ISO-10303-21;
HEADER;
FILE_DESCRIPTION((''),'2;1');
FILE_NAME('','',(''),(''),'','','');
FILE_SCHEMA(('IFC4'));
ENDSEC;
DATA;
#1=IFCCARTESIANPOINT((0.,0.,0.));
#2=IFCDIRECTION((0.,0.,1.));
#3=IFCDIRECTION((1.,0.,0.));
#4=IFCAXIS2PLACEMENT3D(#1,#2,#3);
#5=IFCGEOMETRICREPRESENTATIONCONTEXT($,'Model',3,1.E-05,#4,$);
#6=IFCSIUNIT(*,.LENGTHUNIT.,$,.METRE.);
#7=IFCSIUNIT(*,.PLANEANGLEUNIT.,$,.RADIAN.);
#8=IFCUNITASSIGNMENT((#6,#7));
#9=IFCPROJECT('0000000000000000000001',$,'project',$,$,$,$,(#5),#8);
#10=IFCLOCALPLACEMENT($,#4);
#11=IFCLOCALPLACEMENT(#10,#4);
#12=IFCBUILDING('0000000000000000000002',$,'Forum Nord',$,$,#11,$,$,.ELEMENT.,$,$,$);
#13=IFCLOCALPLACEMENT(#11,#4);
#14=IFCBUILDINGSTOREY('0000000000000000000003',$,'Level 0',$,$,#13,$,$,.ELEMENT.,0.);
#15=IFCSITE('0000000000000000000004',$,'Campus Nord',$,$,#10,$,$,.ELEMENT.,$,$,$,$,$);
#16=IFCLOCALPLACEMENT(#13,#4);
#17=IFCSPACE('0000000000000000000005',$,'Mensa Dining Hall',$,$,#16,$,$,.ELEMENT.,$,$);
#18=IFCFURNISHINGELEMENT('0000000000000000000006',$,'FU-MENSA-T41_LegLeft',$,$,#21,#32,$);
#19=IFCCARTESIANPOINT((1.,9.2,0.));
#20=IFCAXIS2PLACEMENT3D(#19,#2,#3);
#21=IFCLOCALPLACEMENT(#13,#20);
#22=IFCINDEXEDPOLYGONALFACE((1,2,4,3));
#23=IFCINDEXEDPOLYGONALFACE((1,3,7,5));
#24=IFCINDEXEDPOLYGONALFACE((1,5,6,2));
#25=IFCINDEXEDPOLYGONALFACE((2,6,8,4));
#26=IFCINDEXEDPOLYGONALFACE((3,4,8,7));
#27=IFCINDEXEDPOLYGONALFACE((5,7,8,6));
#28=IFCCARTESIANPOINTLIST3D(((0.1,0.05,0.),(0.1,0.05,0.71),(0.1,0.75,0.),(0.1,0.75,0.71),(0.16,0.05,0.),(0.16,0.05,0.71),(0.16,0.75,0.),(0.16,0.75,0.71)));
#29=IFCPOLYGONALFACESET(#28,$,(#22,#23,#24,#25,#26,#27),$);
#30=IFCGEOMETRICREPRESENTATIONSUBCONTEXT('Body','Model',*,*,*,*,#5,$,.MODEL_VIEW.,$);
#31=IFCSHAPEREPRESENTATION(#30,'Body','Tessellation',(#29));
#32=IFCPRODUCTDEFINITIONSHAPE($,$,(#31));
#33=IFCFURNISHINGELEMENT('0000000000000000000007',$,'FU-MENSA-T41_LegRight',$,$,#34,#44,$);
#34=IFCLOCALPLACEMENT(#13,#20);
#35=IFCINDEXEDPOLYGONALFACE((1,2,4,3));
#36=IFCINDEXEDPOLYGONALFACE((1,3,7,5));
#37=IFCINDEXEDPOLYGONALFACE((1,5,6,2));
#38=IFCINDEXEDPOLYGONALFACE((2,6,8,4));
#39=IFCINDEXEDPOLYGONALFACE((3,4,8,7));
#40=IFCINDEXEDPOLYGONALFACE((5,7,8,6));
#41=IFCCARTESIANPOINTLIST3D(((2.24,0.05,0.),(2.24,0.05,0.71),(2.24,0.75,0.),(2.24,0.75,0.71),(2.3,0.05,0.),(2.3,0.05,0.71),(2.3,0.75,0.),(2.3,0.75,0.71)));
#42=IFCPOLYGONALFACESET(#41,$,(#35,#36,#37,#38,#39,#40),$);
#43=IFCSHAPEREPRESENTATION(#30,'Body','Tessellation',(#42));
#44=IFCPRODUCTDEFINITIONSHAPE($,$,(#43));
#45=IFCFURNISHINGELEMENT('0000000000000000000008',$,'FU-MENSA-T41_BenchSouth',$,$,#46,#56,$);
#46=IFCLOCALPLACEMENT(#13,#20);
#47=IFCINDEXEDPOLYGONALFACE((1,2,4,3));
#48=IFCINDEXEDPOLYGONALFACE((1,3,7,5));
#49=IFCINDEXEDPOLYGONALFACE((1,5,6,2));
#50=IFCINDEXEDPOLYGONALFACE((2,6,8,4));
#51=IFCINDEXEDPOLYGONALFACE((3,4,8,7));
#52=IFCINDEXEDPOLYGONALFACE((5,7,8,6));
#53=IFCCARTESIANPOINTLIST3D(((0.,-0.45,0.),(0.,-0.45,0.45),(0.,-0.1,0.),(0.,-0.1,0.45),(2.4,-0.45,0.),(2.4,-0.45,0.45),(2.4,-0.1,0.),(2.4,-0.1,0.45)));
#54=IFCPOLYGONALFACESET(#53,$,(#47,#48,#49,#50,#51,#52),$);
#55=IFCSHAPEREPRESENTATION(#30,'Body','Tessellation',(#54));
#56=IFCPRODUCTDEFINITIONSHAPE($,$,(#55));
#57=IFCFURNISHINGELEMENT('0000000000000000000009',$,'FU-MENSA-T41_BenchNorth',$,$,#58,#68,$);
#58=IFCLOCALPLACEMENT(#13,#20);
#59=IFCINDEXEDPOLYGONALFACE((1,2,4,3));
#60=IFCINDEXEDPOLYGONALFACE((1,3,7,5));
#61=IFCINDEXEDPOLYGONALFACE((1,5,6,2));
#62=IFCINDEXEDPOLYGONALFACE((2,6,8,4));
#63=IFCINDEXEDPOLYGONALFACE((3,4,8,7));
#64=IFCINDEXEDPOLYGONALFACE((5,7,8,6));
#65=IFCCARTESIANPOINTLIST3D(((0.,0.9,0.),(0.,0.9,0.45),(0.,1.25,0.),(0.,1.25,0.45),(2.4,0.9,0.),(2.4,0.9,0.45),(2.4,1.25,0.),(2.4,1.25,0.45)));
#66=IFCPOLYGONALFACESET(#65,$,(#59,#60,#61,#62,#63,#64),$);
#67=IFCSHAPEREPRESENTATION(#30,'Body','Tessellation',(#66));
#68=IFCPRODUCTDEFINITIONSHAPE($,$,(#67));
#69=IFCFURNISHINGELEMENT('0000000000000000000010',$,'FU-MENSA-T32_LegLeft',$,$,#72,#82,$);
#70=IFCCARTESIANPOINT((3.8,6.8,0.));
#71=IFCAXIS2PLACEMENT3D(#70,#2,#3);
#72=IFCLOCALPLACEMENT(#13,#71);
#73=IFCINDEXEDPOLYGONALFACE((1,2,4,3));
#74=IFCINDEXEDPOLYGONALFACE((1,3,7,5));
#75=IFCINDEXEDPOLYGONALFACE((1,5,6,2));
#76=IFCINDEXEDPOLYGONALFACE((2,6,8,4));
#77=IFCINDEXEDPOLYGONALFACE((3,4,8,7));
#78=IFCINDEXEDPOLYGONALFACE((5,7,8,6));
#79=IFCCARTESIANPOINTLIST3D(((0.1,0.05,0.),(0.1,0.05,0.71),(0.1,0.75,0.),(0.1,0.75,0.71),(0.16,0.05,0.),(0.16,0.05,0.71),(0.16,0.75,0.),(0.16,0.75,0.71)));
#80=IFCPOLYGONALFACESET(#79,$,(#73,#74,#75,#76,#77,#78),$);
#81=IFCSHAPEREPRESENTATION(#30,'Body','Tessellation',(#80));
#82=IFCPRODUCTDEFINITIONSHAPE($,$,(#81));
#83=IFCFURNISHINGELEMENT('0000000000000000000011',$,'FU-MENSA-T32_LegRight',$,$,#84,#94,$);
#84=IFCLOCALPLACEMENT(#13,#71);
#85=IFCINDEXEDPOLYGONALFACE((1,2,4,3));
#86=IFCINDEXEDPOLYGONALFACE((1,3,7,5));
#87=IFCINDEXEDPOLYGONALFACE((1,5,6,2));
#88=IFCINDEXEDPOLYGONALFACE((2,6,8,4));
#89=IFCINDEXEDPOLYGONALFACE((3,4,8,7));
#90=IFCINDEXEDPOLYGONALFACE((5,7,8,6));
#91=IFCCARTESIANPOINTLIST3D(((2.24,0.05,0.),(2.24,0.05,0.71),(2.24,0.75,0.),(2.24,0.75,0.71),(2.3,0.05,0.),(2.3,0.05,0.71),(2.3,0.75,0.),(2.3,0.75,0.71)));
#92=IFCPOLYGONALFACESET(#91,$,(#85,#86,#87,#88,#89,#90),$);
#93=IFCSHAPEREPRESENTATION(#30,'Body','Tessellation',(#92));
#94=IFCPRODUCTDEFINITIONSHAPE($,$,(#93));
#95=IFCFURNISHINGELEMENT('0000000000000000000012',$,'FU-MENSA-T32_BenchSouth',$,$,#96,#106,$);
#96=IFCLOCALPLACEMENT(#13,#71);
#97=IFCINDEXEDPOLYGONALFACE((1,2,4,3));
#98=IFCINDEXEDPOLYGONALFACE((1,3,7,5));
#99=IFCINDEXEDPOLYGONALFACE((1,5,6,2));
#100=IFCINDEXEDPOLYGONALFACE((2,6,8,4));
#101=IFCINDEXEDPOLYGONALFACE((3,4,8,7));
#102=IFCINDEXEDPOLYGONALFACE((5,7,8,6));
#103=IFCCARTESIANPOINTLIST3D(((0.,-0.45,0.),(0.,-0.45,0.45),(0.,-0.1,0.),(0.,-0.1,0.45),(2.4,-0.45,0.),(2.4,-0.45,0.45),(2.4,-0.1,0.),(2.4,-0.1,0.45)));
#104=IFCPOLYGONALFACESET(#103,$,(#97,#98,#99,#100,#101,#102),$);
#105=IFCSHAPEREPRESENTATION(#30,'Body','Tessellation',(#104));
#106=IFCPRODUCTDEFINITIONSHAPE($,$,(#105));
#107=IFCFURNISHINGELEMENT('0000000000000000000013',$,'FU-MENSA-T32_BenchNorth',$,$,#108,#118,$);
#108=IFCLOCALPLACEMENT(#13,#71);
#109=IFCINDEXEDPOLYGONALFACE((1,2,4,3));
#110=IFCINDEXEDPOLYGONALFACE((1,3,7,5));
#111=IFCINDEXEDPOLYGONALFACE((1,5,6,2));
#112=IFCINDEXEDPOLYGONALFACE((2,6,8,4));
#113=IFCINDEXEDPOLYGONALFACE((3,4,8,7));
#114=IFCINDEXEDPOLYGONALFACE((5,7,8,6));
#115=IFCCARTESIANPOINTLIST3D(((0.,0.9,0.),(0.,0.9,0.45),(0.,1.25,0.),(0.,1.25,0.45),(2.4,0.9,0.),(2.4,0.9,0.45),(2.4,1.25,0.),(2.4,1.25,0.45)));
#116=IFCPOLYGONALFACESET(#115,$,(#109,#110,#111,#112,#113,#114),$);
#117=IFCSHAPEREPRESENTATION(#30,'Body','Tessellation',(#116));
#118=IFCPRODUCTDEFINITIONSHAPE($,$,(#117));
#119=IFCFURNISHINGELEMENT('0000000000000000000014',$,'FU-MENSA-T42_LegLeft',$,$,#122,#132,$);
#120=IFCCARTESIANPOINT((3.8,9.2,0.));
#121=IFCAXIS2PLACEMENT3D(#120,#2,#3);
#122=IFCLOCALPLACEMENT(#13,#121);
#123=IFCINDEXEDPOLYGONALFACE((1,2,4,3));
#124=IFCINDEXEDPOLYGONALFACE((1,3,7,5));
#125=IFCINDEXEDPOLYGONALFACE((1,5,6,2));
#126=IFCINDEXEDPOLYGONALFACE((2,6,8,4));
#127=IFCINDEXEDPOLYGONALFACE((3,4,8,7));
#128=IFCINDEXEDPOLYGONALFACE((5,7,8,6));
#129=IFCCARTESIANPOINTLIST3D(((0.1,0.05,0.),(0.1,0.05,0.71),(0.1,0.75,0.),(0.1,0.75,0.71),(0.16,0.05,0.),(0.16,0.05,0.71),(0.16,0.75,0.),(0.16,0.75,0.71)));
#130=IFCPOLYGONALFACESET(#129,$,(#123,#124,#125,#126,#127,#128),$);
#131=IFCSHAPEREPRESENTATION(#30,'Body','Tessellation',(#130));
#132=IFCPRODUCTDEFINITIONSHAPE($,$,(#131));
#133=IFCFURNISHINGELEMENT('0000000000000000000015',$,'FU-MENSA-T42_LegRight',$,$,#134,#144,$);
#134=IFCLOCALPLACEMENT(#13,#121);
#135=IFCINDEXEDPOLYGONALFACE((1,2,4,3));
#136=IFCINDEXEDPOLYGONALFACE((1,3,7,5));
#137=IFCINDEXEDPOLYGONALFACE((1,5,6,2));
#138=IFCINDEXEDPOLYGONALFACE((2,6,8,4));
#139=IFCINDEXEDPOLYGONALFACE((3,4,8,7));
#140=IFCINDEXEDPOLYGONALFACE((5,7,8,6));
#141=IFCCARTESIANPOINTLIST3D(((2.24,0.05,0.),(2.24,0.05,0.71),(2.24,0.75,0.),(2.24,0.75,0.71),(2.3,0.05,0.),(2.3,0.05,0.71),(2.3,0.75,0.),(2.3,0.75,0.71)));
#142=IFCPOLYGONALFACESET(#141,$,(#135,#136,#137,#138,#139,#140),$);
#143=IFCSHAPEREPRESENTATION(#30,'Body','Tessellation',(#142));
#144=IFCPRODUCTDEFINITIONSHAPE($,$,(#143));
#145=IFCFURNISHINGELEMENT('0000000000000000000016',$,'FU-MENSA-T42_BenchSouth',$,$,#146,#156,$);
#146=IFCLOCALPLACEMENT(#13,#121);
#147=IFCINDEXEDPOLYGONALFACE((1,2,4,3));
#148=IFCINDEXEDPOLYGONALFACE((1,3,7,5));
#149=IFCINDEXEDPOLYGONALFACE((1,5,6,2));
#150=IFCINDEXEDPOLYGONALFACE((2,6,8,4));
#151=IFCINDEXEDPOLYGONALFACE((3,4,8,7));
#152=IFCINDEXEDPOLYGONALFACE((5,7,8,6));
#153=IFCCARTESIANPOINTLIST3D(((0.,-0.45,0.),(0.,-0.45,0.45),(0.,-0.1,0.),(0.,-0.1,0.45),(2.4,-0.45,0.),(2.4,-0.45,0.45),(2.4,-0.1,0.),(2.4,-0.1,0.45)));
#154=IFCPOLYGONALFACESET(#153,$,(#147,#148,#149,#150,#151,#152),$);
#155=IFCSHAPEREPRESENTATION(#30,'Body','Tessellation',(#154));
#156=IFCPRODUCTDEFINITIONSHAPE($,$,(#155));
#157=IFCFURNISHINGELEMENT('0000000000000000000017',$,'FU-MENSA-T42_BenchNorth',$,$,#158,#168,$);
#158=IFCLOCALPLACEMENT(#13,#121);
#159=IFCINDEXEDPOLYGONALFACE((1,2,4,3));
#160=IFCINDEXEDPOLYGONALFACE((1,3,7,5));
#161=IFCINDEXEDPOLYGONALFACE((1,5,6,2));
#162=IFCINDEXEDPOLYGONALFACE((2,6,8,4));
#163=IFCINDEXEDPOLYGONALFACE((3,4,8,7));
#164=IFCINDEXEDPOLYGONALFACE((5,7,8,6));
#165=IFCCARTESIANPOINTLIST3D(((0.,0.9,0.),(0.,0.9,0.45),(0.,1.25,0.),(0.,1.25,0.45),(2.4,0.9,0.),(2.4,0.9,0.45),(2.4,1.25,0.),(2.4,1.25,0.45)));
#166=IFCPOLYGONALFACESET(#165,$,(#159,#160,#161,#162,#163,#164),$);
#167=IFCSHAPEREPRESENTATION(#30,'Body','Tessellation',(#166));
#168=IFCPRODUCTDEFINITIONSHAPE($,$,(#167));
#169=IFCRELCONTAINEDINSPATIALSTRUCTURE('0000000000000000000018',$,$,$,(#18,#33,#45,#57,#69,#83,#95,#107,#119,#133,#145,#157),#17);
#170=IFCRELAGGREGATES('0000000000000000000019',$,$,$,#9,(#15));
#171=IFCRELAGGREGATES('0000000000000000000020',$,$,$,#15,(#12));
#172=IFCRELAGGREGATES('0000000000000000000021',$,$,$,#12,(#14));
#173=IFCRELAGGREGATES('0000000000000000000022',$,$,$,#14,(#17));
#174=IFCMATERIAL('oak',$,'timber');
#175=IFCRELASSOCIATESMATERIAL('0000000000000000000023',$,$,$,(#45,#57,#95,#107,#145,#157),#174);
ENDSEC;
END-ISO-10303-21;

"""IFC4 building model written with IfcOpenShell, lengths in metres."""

from ifc_helpers import new_model, si_unit, frame, frame_2d, origin_with_axes, place, context, subcontext, project, spatial, rectangle, extrude, material, element, save


model = new_model("IFC4")

# Units and contexts
model_context = context("Model", 3, precision=1e-05, world=origin_with_axes())
body_context = subcontext(model_context, "Body", "Model", "MODEL_VIEW")
ifc_project = project(units=[si_unit("LENGTHUNIT", "METRE"), si_unit("PLANEANGLEUNIT", "RADIAN")], contexts=[model_context])

# Site, building, storey
site_placement = place(None, origin_with_axes())
site = spatial("IfcSite", under=ifc_project, at=site_placement, Name="Campus Nord", CompositionType="ELEMENT")
building_placement = place(site_placement, origin_with_axes())
building = spatial("IfcBuilding", under=site, at=building_placement, Name="Forum Nord", CompositionType="ELEMENT")
storey_placement = place(building_placement, origin_with_axes())
storey = spatial("IfcBuildingStorey", under=building, at=storey_placement, Name="Level 0", CompositionType="ELEMENT", Elevation=0.0)

# Shared definitions
space_placement = place(storey_placement, origin_with_axes())
space = spatial("IfcSpace", under=storey, at=space_placement, Name="Mensa Dining Hall", CompositionType="ELEMENT")

# Furnishing elements
ifc_material_1 = material(Name="oak", Category="timber")
furnishing_1_placement = place(storey_placement, frame((1.0, 9.2, 0.0), z_axis=(0.0, 0.0, 1.0), x_axis=(1.0, 0.0, 0.0)))
element("IfcFurnishingElement", 1, at=furnishing_1_placement, inside=space, Name="FU-MENSA-T41_LegLeft", context=body_context, shape_type="SweptSolid", body=[
    extrude(rectangle(XDim=0.06, YDim=0.7, at=frame_2d((0.13, 0.4), x_axis=(1.0, 0.0))), origin_with_axes(), (0.0, 0.0, 1.0), 0.71),
])
furnishing_2_placement = place(storey_placement, frame((1.0, 9.2, 0.0), z_axis=(0.0, 0.0, 1.0), x_axis=(1.0, 0.0, 0.0)))
element("IfcFurnishingElement", 2, at=furnishing_2_placement, inside=space, Name="FU-MENSA-T41_LegRight", context=body_context, shape_type="SweptSolid", body=[
    extrude(rectangle(XDim=0.06, YDim=0.7, at=frame_2d((2.27, 0.4), x_axis=(1.0, 0.0))), origin_with_axes(), (0.0, 0.0, 1.0), 0.71),
])
furnishing_3_placement = place(storey_placement, frame((1.0, 9.2, 0.0), z_axis=(0.0, 0.0, 1.0), x_axis=(1.0, 0.0, 0.0)))
element("IfcFurnishingElement", 3, at=furnishing_3_placement, inside=space, material=ifc_material_1, Name="FU-MENSA-T41_BenchSouth", context=body_context, shape_type="SweptSolid", body=[
    extrude(rectangle(XDim=2.4, YDim=0.35, at=frame_2d((1.2, -0.275), x_axis=(1.0, 0.0))), origin_with_axes(), (0.0, 0.0, 1.0), 0.45),
])
furnishing_4_placement = place(storey_placement, frame((1.0, 9.2, 0.0), z_axis=(0.0, 0.0, 1.0), x_axis=(1.0, 0.0, 0.0)))
element("IfcFurnishingElement", 4, at=furnishing_4_placement, inside=space, material=ifc_material_1, Name="FU-MENSA-T41_BenchNorth", context=body_context, shape_type="SweptSolid", body=[
    extrude(rectangle(XDim=2.4, YDim=0.35, at=frame_2d((1.2, 1.075), x_axis=(1.0, 0.0))), origin_with_axes(), (0.0, 0.0, 1.0), 0.45),
])
furnishing_5_placement = place(storey_placement, frame((3.8, 6.8, 0.0), z_axis=(0.0, 0.0, 1.0), x_axis=(1.0, 0.0, 0.0)))
element("IfcFurnishingElement", 5, at=furnishing_5_placement, inside=space, Name="FU-MENSA-T32_LegLeft", context=body_context, shape_type="SweptSolid", body=[
    extrude(rectangle(XDim=0.06, YDim=0.7, at=frame_2d((0.13, 0.4), x_axis=(1.0, 0.0))), origin_with_axes(), (0.0, 0.0, 1.0), 0.71),
])
furnishing_6_placement = place(storey_placement, frame((3.8, 6.8, 0.0), z_axis=(0.0, 0.0, 1.0), x_axis=(1.0, 0.0, 0.0)))
element("IfcFurnishingElement", 6, at=furnishing_6_placement, inside=space, Name="FU-MENSA-T32_LegRight", context=body_context, shape_type="SweptSolid", body=[
    extrude(rectangle(XDim=0.06, YDim=0.7, at=frame_2d((2.27, 0.4), x_axis=(1.0, 0.0))), origin_with_axes(), (0.0, 0.0, 1.0), 0.71),
])
furnishing_7_placement = place(storey_placement, frame((3.8, 6.8, 0.0), z_axis=(0.0, 0.0, 1.0), x_axis=(1.0, 0.0, 0.0)))
element("IfcFurnishingElement", 7, at=furnishing_7_placement, inside=space, material=ifc_material_1, Name="FU-MENSA-T32_BenchSouth", context=body_context, shape_type="SweptSolid", body=[
    extrude(rectangle(XDim=2.4, YDim=0.35, at=frame_2d((1.2, -0.275), x_axis=(1.0, 0.0))), origin_with_axes(), (0.0, 0.0, 1.0), 0.45),
])
furnishing_8_placement = place(storey_placement, frame((3.8, 6.8, 0.0), z_axis=(0.0, 0.0, 1.0), x_axis=(1.0, 0.0, 0.0)))
element("IfcFurnishingElement", 8, at=furnishing_8_placement, inside=space, material=ifc_material_1, Name="FU-MENSA-T32_BenchNorth", context=body_context, shape_type="SweptSolid", body=[
    extrude(rectangle(XDim=2.4, YDim=0.35, at=frame_2d((1.2, 1.075), x_axis=(1.0, 0.0))), origin_with_axes(), (0.0, 0.0, 1.0), 0.45),
])
furnishing_9_placement = place(storey_placement, frame((3.8, 9.2, 0.0), z_axis=(0.0, 0.0, 1.0), x_axis=(1.0, 0.0, 0.0)))
element("IfcFurnishingElement", 9, at=furnishing_9_placement, inside=space, Name="FU-MENSA-T42_LegLeft", context=body_context, shape_type="SweptSolid", body=[
    extrude(rectangle(XDim=0.06, YDim=0.7, at=frame_2d((0.13, 0.4), x_axis=(1.0, 0.0))), origin_with_axes(), (0.0, 0.0, 1.0), 0.71),
])
furnishing_10_placement = place(storey_placement, frame((3.8, 9.2, 0.0), z_axis=(0.0, 0.0, 1.0), x_axis=(1.0, 0.0, 0.0)))
element("IfcFurnishingElement", 10, at=furnishing_10_placement, inside=space, Name="FU-MENSA-T42_LegRight", context=body_context, shape_type="SweptSolid", body=[
    extrude(rectangle(XDim=0.06, YDim=0.7, at=frame_2d((2.27, 0.4), x_axis=(1.0, 0.0))), origin_with_axes(), (0.0, 0.0, 1.0), 0.71),
])
furnishing_11_placement = place(storey_placement, frame((3.8, 9.2, 0.0), z_axis=(0.0, 0.0, 1.0), x_axis=(1.0, 0.0, 0.0)))
element("IfcFurnishingElement", 11, at=furnishing_11_placement, inside=space, material=ifc_material_1, Name="FU-MENSA-T42_BenchSouth", context=body_context, shape_type="SweptSolid", body=[
    extrude(rectangle(XDim=2.4, YDim=0.35, at=frame_2d((1.2, -0.275), x_axis=(1.0, 0.0))), origin_with_axes(), (0.0, 0.0, 1.0), 0.45),
])
furnishing_12_placement = place(storey_placement, frame((3.8, 9.2, 0.0), z_axis=(0.0, 0.0, 1.0), x_axis=(1.0, 0.0, 0.0)))
element("IfcFurnishingElement", 12, at=furnishing_12_placement, inside=space, material=ifc_material_1, Name="FU-MENSA-T42_BenchNorth", context=body_context, shape_type="SweptSolid", body=[
    extrude(rectangle(XDim=2.4, YDim=0.35, at=frame_2d((1.2, 1.075), x_axis=(1.0, 0.0))), origin_with_axes(), (0.0, 0.0, 1.0), 0.45),
])

save(model, "model.ifc")
